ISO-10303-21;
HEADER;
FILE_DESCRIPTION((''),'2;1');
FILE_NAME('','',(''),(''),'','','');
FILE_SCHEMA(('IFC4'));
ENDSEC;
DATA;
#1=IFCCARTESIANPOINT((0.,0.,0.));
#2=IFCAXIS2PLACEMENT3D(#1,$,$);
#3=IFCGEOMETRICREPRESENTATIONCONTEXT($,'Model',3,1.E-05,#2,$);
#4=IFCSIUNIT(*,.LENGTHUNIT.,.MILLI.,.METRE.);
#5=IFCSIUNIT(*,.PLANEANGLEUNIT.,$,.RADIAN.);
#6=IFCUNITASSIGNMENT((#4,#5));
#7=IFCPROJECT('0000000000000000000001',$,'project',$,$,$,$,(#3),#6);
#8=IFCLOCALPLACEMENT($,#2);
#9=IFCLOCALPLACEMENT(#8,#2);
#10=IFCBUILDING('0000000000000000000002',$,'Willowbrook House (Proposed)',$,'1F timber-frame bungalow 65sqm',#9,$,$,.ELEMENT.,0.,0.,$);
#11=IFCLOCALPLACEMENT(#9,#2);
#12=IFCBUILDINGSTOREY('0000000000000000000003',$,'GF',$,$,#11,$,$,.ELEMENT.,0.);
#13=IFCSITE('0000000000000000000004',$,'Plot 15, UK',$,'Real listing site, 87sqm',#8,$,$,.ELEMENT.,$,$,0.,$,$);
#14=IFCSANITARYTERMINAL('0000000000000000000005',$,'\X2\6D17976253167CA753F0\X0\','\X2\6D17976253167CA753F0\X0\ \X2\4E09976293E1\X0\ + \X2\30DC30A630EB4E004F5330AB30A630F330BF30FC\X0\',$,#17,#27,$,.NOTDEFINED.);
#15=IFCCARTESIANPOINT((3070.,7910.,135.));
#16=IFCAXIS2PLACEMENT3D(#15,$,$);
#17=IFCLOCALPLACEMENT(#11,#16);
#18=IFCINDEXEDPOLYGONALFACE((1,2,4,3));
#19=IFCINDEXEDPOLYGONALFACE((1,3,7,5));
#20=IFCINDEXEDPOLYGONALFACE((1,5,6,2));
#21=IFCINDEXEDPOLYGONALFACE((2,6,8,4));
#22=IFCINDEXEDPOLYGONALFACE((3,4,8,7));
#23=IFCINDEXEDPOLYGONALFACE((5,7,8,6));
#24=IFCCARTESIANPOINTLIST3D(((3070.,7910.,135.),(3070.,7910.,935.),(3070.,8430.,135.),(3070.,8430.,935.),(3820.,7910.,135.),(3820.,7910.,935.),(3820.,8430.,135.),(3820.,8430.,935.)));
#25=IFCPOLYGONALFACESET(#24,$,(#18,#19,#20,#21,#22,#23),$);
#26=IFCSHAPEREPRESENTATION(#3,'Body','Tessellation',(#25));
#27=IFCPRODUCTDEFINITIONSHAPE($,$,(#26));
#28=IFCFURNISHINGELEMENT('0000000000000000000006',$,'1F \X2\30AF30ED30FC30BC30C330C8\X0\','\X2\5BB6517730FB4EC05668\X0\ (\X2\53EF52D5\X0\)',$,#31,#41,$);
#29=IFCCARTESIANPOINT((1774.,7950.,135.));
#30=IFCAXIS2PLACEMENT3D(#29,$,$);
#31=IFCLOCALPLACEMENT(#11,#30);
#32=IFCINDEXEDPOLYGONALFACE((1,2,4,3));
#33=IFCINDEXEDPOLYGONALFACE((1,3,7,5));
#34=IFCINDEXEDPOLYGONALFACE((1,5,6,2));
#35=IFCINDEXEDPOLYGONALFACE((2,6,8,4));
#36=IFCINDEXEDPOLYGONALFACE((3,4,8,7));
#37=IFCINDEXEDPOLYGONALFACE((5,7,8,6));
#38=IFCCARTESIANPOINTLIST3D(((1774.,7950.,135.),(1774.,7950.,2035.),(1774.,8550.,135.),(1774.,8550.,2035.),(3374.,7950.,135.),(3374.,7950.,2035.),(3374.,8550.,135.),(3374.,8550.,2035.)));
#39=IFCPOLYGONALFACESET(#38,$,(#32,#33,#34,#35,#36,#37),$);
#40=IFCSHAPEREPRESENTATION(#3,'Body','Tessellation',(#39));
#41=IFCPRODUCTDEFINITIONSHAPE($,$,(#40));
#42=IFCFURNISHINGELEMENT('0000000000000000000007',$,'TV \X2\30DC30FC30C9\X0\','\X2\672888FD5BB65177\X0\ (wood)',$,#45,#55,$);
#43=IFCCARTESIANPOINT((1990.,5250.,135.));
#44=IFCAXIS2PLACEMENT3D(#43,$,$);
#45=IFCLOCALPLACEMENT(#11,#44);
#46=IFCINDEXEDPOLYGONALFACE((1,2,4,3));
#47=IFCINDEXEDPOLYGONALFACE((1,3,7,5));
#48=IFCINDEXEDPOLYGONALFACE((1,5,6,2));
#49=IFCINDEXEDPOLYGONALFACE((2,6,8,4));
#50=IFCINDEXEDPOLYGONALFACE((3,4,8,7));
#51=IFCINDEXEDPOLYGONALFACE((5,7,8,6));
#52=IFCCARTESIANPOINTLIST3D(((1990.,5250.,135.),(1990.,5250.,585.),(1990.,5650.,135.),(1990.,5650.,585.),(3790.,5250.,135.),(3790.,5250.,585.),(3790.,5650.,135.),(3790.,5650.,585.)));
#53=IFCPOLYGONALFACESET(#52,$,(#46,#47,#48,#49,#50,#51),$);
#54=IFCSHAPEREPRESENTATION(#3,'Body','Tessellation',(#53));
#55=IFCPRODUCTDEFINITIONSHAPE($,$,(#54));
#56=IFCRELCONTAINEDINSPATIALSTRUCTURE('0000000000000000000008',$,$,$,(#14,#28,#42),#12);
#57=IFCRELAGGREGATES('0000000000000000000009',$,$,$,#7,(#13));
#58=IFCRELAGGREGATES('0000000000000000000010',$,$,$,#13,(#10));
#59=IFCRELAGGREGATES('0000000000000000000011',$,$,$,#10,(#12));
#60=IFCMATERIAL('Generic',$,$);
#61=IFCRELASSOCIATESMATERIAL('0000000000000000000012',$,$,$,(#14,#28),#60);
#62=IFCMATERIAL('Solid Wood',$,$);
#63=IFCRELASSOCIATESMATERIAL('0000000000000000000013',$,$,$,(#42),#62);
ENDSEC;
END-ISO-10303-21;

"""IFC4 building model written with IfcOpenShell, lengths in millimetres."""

from ifc_helpers import new_model, si_unit, frame, frame_2d, origin, place, context, project, spatial, rectangle, extrude, material, element, save


model = new_model("IFC4")

# Units and contexts
model_context = context("Model", 3, precision=1e-05, world=origin())
ifc_project = project(units=[si_unit("LENGTHUNIT", "METRE", prefix="MILLI"), si_unit("PLANEANGLEUNIT", "RADIAN")], contexts=[model_context])

# Site, building, storey
site_placement = place(None, origin())
site = spatial("IfcSite", under=ifc_project, at=site_placement, Name="Plot 15, UK", ObjectType="Real listing site, 87sqm", CompositionType="ELEMENT", RefElevation=0.0)
building_placement = place(site_placement, origin())
building = spatial("IfcBuilding", under=site, at=building_placement, Name="Willowbrook House (Proposed)", ObjectType="1F timber-frame bungalow 65sqm", CompositionType="ELEMENT", ElevationOfRefHeight=0.0, ElevationOfTerrain=0.0)
storey_placement = place(building_placement, origin())
storey = spatial("IfcBuildingStorey", under=building, at=storey_placement, Name="GF", CompositionType="ELEMENT", Elevation=0.0)

# Shared definitions
ifc_material_1 = material(Name="Solid Wood")

# Shared definitions
ifc_material_2 = material(Name="Generic")

# Sanitary terminal
sanitary_terminal_1_placement = place(storey_placement, frame((3070.0, 7910.0, 135.0)))
element("IfcSanitaryTerminal", 1, at=sanitary_terminal_1_placement, inside=storey, material=ifc_material_2, Name="洗面化粧台", Description="洗面化粧台 三面鏡 + ボウル一体カウンター", PredefinedType="NOTDEFINED", context=model_context, shape_type="SweptSolid", body=[
    extrude(rectangle(XDim=750.0, YDim=520.0, at=frame_2d((375.0, 260.0))), frame((3070.0, 7910.0, 135.0)), (0.0, 0.0, 1.0), 800.0),
])

# Furnishing elements
furnishing_1_placement = place(storey_placement, frame((1774.0, 7950.0, 135.0)))
element("IfcFurnishingElement", 2, at=furnishing_1_placement, inside=storey, material=ifc_material_2, Name="1F クローゼット", Description="家具・什器 (可動)", context=model_context, shape_type="SweptSolid", body=[
    extrude(rectangle(XDim=1600.0, YDim=600.0, at=frame_2d((800.0, 300.0))), frame((1774.0, 7950.0, 135.0)), (0.0, 0.0, 1.0), 1900.0),
])
furnishing_2_placement = place(storey_placement, frame((1990.0, 5250.0, 135.0)))
element("IfcFurnishingElement", 3, at=furnishing_2_placement, inside=storey, material=ifc_material_1, Name="TV ボード", Description="木製家具 (wood)", context=model_context, shape_type="SweptSolid", body=[
    extrude(rectangle(XDim=1800.0, YDim=400.0, at=frame_2d((900.0, 200.0))), frame((1990.0, 5250.0, 135.0)), (0.0, 0.0, 1.0), 450.0),
])

save(model, "model.ifc")
